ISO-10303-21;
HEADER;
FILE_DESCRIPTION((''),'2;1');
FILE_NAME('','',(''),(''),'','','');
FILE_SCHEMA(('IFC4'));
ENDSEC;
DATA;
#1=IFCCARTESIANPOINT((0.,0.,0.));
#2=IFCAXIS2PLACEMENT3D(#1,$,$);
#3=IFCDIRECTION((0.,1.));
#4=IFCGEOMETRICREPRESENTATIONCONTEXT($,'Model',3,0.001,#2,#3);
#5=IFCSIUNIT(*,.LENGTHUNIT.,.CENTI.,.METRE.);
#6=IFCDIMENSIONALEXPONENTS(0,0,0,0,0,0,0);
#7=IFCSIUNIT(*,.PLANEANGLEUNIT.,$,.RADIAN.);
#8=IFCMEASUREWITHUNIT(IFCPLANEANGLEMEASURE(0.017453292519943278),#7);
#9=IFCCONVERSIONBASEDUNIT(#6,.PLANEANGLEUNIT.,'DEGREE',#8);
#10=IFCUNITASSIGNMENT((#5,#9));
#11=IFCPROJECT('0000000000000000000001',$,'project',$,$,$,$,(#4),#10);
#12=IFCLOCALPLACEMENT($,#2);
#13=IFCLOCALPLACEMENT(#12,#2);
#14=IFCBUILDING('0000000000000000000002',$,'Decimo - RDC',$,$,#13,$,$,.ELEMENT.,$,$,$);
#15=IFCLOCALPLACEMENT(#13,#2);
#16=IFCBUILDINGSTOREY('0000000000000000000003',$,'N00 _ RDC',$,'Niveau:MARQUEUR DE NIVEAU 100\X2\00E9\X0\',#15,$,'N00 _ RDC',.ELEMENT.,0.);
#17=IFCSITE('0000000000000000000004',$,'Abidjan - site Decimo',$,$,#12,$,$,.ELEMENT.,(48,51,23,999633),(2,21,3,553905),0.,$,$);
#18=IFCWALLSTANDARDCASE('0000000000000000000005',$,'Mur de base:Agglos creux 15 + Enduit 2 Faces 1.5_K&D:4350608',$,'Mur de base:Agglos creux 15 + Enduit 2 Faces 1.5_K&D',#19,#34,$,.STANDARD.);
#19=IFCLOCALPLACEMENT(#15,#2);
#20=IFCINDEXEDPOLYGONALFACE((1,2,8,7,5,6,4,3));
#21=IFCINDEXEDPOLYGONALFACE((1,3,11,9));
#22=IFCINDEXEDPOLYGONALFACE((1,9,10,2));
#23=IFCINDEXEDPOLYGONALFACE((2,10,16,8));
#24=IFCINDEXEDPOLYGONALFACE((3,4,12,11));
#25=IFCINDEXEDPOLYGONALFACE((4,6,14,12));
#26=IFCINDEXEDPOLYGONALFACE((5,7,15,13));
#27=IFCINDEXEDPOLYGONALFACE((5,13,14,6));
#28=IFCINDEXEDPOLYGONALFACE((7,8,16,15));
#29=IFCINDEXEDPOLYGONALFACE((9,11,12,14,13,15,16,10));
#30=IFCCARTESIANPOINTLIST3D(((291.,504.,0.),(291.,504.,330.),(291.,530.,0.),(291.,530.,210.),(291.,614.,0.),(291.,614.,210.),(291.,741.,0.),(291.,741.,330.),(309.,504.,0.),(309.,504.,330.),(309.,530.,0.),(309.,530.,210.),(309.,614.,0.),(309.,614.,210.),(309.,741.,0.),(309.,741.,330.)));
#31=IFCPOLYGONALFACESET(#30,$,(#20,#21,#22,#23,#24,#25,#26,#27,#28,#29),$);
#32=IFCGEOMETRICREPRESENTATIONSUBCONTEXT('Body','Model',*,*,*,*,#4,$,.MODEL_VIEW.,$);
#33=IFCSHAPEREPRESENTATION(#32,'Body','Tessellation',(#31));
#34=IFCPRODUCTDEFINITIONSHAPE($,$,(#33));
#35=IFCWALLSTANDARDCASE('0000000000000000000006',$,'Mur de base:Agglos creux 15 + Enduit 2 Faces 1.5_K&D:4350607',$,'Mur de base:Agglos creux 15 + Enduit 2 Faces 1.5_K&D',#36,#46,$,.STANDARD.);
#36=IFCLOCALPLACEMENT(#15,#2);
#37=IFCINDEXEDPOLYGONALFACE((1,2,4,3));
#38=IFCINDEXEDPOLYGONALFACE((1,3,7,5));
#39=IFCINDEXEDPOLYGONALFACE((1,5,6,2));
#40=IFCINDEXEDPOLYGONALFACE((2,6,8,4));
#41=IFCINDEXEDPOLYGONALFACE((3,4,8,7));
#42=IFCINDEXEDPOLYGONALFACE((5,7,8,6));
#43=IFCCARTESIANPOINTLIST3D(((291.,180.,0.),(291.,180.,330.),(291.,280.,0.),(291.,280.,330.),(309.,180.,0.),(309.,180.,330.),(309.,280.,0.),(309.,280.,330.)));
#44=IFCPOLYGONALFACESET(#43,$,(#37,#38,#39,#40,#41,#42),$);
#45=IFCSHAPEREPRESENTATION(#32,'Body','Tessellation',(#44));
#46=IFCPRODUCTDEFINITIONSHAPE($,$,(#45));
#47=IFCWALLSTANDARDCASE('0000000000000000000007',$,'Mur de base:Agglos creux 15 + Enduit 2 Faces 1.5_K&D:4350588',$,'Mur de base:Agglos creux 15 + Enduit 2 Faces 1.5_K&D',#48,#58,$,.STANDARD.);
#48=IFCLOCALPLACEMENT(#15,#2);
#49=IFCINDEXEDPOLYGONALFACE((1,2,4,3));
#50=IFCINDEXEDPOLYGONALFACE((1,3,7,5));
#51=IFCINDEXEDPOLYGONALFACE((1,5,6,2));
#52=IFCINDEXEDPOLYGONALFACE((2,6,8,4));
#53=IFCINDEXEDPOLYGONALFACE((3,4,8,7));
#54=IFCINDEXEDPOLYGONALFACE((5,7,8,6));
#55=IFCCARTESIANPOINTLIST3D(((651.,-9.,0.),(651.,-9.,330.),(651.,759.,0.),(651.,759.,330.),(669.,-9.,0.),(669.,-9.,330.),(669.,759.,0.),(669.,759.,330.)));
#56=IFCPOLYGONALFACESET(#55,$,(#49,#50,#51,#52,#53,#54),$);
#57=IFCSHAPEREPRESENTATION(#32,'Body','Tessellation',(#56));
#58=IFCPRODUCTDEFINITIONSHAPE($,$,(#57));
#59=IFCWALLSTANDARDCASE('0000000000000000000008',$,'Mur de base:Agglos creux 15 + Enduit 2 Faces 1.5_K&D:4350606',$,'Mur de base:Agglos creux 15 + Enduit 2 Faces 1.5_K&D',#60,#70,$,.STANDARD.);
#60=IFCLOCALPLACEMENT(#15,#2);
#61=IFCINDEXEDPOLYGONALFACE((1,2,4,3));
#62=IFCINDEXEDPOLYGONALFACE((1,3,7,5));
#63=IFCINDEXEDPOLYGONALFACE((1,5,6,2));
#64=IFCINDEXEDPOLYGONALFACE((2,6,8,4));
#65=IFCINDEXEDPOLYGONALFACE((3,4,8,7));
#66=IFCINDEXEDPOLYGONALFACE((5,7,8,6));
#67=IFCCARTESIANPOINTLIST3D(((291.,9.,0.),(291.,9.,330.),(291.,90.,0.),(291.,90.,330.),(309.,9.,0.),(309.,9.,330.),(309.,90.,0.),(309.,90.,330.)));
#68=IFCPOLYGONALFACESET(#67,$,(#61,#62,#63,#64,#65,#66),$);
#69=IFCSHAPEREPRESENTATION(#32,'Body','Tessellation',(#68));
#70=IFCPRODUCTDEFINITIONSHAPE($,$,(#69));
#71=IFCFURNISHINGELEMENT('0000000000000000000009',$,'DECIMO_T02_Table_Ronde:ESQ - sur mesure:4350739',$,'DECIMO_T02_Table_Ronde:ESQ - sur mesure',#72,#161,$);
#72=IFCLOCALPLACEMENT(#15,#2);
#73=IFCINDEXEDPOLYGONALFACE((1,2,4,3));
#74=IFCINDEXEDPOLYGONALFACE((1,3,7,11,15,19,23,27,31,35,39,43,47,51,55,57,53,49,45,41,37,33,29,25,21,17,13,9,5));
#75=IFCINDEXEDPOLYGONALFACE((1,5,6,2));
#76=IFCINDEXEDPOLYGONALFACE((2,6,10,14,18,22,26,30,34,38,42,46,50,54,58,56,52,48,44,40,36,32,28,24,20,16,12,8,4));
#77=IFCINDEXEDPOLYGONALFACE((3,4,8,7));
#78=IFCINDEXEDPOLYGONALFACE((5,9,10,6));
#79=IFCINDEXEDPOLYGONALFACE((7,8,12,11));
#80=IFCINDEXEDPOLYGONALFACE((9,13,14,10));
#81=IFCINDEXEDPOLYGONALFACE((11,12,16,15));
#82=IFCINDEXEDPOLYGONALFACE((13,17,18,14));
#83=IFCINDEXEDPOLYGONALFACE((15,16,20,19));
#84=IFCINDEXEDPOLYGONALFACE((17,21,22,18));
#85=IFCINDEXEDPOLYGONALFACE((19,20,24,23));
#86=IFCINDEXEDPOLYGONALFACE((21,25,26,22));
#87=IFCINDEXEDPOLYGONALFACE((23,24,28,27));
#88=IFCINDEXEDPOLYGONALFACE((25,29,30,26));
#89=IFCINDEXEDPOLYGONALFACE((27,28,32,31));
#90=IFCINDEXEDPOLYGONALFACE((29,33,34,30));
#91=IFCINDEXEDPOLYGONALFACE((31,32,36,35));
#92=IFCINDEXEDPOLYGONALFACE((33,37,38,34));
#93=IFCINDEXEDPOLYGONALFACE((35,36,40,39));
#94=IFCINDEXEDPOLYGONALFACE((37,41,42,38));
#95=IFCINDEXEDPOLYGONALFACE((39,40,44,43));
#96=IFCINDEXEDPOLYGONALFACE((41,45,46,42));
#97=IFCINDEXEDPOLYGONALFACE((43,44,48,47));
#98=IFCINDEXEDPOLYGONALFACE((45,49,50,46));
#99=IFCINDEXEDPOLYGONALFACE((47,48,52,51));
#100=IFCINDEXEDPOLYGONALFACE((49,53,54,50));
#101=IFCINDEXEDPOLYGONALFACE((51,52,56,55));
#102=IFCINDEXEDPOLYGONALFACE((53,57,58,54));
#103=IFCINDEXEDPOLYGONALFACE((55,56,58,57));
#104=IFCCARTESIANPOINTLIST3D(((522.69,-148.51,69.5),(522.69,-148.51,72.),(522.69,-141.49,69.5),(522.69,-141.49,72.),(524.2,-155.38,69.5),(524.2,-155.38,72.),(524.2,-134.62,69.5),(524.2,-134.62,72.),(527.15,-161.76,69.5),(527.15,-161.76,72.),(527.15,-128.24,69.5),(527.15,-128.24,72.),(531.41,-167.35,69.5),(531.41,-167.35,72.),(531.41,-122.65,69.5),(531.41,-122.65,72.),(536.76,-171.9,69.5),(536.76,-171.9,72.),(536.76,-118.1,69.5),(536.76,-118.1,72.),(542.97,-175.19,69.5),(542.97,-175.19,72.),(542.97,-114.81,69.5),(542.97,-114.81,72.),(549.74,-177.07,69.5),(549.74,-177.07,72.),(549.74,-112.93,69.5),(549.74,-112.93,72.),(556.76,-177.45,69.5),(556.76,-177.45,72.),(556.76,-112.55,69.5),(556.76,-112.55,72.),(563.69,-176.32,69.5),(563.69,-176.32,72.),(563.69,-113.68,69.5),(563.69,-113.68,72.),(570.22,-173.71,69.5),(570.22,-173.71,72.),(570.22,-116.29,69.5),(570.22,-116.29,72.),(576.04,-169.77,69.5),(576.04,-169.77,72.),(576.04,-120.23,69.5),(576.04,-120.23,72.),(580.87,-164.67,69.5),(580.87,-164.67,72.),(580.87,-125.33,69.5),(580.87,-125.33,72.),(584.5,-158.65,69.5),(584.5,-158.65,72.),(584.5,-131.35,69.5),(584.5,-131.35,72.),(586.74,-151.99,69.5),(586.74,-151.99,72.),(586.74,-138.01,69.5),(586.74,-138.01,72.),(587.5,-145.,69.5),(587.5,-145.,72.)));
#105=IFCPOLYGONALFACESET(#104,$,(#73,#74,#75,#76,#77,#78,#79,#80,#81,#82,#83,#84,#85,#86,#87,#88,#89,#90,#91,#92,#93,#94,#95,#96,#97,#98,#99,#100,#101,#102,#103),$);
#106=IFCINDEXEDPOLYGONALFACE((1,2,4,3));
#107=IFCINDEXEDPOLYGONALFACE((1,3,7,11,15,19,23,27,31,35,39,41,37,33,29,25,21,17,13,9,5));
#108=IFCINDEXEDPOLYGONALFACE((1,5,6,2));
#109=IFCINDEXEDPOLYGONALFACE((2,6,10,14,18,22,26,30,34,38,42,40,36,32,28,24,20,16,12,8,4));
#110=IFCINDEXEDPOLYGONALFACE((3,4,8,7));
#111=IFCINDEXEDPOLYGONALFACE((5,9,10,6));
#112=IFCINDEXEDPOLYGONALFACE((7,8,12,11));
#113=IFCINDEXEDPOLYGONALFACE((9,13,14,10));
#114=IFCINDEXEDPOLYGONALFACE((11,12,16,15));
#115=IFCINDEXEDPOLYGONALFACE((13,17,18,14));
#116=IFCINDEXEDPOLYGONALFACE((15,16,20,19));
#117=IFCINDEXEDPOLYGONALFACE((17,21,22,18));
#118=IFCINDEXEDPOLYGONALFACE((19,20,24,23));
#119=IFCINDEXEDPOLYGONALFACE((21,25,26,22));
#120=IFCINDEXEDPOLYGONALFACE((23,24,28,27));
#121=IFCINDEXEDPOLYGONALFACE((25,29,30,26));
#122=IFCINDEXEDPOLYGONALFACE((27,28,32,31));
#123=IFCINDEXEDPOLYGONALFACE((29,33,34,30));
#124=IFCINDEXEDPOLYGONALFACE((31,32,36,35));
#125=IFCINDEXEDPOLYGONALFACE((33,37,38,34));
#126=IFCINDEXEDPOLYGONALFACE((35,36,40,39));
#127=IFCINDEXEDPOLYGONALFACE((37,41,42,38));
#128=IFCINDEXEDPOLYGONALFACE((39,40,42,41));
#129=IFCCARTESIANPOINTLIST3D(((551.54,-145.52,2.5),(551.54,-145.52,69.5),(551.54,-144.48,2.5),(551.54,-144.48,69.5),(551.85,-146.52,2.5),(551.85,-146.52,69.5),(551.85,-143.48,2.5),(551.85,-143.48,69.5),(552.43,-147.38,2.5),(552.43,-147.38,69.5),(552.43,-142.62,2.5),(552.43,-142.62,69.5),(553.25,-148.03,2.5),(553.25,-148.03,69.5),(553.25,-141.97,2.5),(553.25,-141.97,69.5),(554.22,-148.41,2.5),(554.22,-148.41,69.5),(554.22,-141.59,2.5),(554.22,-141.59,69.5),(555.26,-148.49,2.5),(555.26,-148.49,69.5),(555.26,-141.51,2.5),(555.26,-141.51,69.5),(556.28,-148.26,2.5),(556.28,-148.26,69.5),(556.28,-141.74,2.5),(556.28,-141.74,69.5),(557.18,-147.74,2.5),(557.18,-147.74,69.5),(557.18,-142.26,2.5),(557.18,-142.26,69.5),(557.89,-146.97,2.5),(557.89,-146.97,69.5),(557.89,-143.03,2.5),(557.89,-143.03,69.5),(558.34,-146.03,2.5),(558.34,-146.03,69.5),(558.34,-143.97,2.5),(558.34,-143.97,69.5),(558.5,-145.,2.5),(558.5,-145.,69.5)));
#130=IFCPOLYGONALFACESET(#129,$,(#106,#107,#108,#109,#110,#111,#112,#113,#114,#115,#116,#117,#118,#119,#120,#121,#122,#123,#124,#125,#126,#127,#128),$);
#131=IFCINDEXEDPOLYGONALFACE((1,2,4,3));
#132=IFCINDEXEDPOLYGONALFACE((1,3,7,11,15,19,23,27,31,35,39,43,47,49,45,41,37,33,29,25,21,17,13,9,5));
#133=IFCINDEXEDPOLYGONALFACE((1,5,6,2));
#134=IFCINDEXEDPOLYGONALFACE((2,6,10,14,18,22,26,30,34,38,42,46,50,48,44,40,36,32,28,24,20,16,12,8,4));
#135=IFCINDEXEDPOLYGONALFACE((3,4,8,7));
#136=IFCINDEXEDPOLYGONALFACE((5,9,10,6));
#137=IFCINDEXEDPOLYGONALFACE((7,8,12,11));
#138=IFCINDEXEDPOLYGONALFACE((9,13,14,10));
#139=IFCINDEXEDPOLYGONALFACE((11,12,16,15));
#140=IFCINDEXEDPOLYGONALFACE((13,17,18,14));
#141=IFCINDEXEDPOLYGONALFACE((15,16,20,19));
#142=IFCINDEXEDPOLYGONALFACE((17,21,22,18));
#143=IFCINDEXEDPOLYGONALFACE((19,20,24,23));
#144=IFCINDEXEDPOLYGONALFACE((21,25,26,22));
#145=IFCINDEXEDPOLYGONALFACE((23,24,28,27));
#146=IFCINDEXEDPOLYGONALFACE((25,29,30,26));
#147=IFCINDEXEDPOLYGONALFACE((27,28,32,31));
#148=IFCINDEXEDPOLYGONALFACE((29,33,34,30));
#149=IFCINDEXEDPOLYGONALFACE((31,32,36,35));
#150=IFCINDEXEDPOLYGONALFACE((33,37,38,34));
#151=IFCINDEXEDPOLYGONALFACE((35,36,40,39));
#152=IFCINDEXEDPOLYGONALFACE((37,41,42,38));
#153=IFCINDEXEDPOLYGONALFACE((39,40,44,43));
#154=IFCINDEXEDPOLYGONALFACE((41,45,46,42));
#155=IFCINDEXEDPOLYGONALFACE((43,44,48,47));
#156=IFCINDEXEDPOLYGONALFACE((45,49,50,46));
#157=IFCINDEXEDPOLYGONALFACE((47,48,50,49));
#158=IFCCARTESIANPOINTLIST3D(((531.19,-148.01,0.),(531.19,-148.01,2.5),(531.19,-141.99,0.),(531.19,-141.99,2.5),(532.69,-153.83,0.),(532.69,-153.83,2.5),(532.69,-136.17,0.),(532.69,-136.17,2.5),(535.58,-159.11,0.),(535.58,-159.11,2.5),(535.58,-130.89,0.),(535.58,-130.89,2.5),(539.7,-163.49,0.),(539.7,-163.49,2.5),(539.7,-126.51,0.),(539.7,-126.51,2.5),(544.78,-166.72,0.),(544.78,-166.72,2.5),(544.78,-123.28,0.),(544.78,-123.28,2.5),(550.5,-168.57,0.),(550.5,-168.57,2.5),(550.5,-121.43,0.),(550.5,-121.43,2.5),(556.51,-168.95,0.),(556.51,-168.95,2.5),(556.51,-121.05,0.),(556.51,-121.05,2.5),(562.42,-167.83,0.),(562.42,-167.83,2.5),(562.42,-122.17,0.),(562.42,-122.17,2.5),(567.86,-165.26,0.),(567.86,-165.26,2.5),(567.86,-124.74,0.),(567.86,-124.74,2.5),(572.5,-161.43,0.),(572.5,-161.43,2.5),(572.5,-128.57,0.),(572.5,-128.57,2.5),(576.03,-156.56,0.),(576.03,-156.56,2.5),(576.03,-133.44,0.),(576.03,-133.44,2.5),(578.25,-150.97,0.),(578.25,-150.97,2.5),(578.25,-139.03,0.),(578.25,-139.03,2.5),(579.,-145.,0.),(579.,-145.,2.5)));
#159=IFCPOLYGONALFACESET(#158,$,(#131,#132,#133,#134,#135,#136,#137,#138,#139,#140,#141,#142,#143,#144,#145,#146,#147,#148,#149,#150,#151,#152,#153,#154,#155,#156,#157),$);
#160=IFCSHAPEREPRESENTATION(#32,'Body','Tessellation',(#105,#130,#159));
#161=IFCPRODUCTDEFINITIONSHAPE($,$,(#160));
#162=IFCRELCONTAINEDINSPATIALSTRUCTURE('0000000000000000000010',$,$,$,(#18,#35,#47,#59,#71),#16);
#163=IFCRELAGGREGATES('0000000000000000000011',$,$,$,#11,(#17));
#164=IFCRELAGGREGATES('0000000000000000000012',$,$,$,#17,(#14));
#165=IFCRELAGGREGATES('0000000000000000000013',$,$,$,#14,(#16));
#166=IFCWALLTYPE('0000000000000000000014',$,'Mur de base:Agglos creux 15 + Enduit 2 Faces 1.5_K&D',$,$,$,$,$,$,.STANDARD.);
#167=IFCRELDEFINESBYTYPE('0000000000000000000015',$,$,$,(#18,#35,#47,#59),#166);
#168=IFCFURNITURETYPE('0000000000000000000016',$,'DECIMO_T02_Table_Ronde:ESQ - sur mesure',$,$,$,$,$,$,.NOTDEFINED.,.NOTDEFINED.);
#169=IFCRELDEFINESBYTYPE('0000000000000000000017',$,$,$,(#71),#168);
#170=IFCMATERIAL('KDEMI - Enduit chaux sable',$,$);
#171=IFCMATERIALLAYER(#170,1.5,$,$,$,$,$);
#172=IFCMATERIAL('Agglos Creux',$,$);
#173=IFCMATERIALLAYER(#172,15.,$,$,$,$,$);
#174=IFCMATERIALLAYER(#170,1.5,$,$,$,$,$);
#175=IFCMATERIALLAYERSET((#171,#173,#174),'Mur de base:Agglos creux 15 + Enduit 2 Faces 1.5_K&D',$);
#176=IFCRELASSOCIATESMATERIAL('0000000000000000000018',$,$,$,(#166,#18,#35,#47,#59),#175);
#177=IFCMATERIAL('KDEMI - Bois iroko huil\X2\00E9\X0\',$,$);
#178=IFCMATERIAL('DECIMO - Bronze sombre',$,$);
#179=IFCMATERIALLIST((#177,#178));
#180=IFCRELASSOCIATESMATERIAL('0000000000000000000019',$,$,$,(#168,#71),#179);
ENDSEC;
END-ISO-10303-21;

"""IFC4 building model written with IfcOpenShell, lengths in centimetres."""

from ifc_helpers import new_model, entity, si_unit, converted_unit, direction, frame, frame_2d, origin, place, context, subcontext, project, spatial, rectangle, circle, extrude, source, transform, mapped, material, material_list, layer, layer_set, layer_usage, type_object, type_shapes, element, save


model = new_model("IFC4")

# Units and contexts
model_context = context("Model", 3, precision=0.001, world=origin(), true_north=direction((0.0, 1.0)))
body_context = subcontext(model_context, "Body", "Model", "MODEL_VIEW")
ifc_project = project(units=[si_unit("LENGTHUNIT", "METRE", prefix="CENTI"), converted_unit("PLANEANGLEUNIT", "DEGREE", entity("IfcPlaneAngleMeasure", 0.017453292519943278), si_unit("PLANEANGLEUNIT", "RADIAN"), dimensions=[0, 0, 0, 0, 0, 0, 0])], contexts=[model_context])

# Site, building, storey
site_placement = place(None, origin())
site = spatial("IfcSite", under=ifc_project, at=site_placement, Name="Abidjan - site Decimo", CompositionType="ELEMENT", RefLatitude=(48, 51, 23, 999633), RefLongitude=(2, 21, 3, 553905), RefElevation=0.0)
building_placement = place(site_placement, origin())
building = spatial("IfcBuilding", under=site, at=building_placement, Name="Decimo - RDC", CompositionType="ELEMENT")
storey_placement = place(building_placement, origin())
storey = spatial("IfcBuildingStorey", under=building, at=storey_placement, Name="N00 _ RDC", ObjectType="Niveau:MARQUEUR DE NIVEAU 100é", LongName="N00 _ RDC", CompositionType="ELEMENT", Elevation=0.0)

# Wall, opening
ifc_material_1 = material(Name="KDEMI - Enduit chaux sable")
ifc_layer_1 = layer(ifc_material_1, 1.5)
ifc_material_2 = material(Name="Agglos Creux")
ifc_layer_2 = layer(ifc_material_2, 15.0)
ifc_layer_3 = layer(ifc_material_1, 1.5)
ifc_layer_set = layer_set([ifc_layer_1, ifc_layer_2, ifc_layer_3], Name="Mur de base:Agglos creux 15 + Enduit 2 Faces 1.5_K&D")
ifc_layer_usage_1 = layer_usage(ifc_layer_set, "AXIS2", "POSITIVE", -9.0)
wall_type = type_object("IfcWallType", Name="Mur de base:Agglos creux 15 + Enduit 2 Faces 1.5_K&D", PredefinedType="STANDARD", material=ifc_layer_set)
wall_1_placement = place(storey_placement, frame((300.0, 504.0, 0.0), z_axis=(0.0, 0.0, 1.0), x_axis=(0.0, 1.0, 0.0)))
wall_1 = element("IfcWallStandardCase", 1, at=wall_1_placement, inside=storey, type_object=wall_type, material=ifc_layer_usage_1, Name="Mur de base:Agglos creux 15 + Enduit 2 Faces 1.5_K&D:4350608", ObjectType="Mur de base:Agglos creux 15 + Enduit 2 Faces 1.5_K&D", PredefinedType="STANDARD", context=body_context, shape_type="SweptSolid", body=[
    extrude(rectangle(XDim=237.0, YDim=18.0, at=frame_2d((118.5, 0.0), x_axis=(1.0, 0.0))), origin(), (0.0, 0.0, 1.0), 330.0),
])
opening_placement = place(wall_1_placement, frame((-504.0, 300.0, 0.0), z_axis=(0.0, 0.0, 1.0), x_axis=(0.0, -1.0, 0.0)))
element("IfcOpeningElement", 2, at=opening_placement, inside=storey, cuts=wall_1, context=body_context, shape_type="SweptSolid", body=[
    extrude(rectangle(XDim=22.0, YDim=84.0, at=frame_2d((300.0, 572.0))), origin(), (0.0, 0.0, 1.0), 210.0),
])

# Walls
ifc_layer_usage_2 = layer_usage(ifc_layer_set, "AXIS2", "NEGATIVE", 9.0)
wall_2_placement = place(storey_placement, frame((300.0, 180.0, 0.0), z_axis=(0.0, 0.0, 1.0), x_axis=(0.0, 1.0, 0.0)))
element("IfcWallStandardCase", 3, at=wall_2_placement, inside=storey, type_object=wall_type, material=ifc_layer_usage_2, Name="Mur de base:Agglos creux 15 + Enduit 2 Faces 1.5_K&D:4350607", ObjectType="Mur de base:Agglos creux 15 + Enduit 2 Faces 1.5_K&D", PredefinedType="STANDARD", context=body_context, shape_type="SweptSolid", body=[
    extrude(rectangle(XDim=100.0, YDim=18.0, at=frame_2d((50.0, 0.0), x_axis=(-1.0, 0.0))), origin(), (0.0, 0.0, 1.0), 330.0),
])
ifc_layer_usage_3 = layer_usage(ifc_layer_set, "AXIS2", "NEGATIVE", 9.0)
wall_3_placement = place(storey_placement, frame((660.0, -9.0, 0.0), z_axis=(0.0, 0.0, 1.0), x_axis=(0.0, 1.0, 0.0)))
element("IfcWallStandardCase", 4, at=wall_3_placement, inside=storey, type_object=wall_type, material=ifc_layer_usage_3, Name="Mur de base:Agglos creux 15 + Enduit 2 Faces 1.5_K&D:4350588", ObjectType="Mur de base:Agglos creux 15 + Enduit 2 Faces 1.5_K&D", PredefinedType="STANDARD", context=body_context, shape_type="SweptSolid", body=[
    extrude(rectangle(XDim=768.0, YDim=18.0, at=frame_2d((384.0, 0.0), x_axis=(-1.0, 0.0))), origin(), (0.0, 0.0, 1.0), 330.0),
])
ifc_layer_usage_4 = layer_usage(ifc_layer_set, "AXIS2", "NEGATIVE", 9.0)
wall_4_placement = place(storey_placement, frame((300.0, 9.0, 0.0), z_axis=(0.0, 0.0, 1.0), x_axis=(0.0, 1.0, 0.0)))
element("IfcWallStandardCase", 5, at=wall_4_placement, inside=storey, type_object=wall_type, material=ifc_layer_usage_4, Name="Mur de base:Agglos creux 15 + Enduit 2 Faces 1.5_K&D:4350606", ObjectType="Mur de base:Agglos creux 15 + Enduit 2 Faces 1.5_K&D", PredefinedType="STANDARD", context=body_context, shape_type="SweptSolid", body=[
    extrude(rectangle(XDim=81.0, YDim=18.0, at=frame_2d((40.5, 0.0), x_axis=(-1.0, 0.0))), origin(), (0.0, 0.0, 1.0), 330.0),
])

# Furnishing element
ifc_material_3 = material(Name="KDEMI - Bois iroko huilé")
ifc_material_4 = material(Name="DECIMO - Bronze sombre")
ifc_material_list_1 = material_list([ifc_material_3, ifc_material_4])
furniture_type_1 = type_object("IfcFurnitureType", Name="DECIMO_T02_Table_Ronde:ESQ - sur mesure", AssemblyPlace="NOTDEFINED", material=ifc_material_list_1)
shared_shape_1 = source(origin(), body_context, "Body", "SweptSolid", [
    extrude(circle(Radius=32.5, at=frame_2d((0.0, 0.0), x_axis=(1.0, 0.0))), frame((0.0, 0.0, 69.5)), (0.0, 0.0, 1.0), 2.5),
    extrude(circle(Radius=3.5, at=frame_2d((0.0, 0.0), x_axis=(1.0, 0.0))), frame((0.0, 0.0, 2.5)), (0.0, 0.0, 1.0), 67.0),
    extrude(circle(Radius=24.0, at=frame_2d((0.0, 0.0), x_axis=(1.0, 0.0))), origin(), (0.0, 0.0, 1.0), 2.5),
])
type_shapes(furniture_type_1, [shared_shape_1])
for number, where, z_axis, x_axis, name in (
    (6, (555.0, -145.0, 0.0), (0.0, 0.0, 1.0), (1.0, 0.0, 0.0), "DECIMO_T02_Table_Ronde:ESQ - sur mesure:4350739"),
):
    element("IfcFurnishingElement", number, at=place(storey_placement, frame(where, z_axis=z_axis, x_axis=x_axis)), inside=storey, type_object=furniture_type_1, material=ifc_material_list_1, Name=name, ObjectType="DECIMO_T02_Table_Ronde:ESQ - sur mesure", context=body_context, shape_type="MappedRepresentation", body=[
        mapped(shared_shape_1, transform((0.0, 0.0, 0.0), scale=1.0)),
    ])

save(model, "model.ifc")
